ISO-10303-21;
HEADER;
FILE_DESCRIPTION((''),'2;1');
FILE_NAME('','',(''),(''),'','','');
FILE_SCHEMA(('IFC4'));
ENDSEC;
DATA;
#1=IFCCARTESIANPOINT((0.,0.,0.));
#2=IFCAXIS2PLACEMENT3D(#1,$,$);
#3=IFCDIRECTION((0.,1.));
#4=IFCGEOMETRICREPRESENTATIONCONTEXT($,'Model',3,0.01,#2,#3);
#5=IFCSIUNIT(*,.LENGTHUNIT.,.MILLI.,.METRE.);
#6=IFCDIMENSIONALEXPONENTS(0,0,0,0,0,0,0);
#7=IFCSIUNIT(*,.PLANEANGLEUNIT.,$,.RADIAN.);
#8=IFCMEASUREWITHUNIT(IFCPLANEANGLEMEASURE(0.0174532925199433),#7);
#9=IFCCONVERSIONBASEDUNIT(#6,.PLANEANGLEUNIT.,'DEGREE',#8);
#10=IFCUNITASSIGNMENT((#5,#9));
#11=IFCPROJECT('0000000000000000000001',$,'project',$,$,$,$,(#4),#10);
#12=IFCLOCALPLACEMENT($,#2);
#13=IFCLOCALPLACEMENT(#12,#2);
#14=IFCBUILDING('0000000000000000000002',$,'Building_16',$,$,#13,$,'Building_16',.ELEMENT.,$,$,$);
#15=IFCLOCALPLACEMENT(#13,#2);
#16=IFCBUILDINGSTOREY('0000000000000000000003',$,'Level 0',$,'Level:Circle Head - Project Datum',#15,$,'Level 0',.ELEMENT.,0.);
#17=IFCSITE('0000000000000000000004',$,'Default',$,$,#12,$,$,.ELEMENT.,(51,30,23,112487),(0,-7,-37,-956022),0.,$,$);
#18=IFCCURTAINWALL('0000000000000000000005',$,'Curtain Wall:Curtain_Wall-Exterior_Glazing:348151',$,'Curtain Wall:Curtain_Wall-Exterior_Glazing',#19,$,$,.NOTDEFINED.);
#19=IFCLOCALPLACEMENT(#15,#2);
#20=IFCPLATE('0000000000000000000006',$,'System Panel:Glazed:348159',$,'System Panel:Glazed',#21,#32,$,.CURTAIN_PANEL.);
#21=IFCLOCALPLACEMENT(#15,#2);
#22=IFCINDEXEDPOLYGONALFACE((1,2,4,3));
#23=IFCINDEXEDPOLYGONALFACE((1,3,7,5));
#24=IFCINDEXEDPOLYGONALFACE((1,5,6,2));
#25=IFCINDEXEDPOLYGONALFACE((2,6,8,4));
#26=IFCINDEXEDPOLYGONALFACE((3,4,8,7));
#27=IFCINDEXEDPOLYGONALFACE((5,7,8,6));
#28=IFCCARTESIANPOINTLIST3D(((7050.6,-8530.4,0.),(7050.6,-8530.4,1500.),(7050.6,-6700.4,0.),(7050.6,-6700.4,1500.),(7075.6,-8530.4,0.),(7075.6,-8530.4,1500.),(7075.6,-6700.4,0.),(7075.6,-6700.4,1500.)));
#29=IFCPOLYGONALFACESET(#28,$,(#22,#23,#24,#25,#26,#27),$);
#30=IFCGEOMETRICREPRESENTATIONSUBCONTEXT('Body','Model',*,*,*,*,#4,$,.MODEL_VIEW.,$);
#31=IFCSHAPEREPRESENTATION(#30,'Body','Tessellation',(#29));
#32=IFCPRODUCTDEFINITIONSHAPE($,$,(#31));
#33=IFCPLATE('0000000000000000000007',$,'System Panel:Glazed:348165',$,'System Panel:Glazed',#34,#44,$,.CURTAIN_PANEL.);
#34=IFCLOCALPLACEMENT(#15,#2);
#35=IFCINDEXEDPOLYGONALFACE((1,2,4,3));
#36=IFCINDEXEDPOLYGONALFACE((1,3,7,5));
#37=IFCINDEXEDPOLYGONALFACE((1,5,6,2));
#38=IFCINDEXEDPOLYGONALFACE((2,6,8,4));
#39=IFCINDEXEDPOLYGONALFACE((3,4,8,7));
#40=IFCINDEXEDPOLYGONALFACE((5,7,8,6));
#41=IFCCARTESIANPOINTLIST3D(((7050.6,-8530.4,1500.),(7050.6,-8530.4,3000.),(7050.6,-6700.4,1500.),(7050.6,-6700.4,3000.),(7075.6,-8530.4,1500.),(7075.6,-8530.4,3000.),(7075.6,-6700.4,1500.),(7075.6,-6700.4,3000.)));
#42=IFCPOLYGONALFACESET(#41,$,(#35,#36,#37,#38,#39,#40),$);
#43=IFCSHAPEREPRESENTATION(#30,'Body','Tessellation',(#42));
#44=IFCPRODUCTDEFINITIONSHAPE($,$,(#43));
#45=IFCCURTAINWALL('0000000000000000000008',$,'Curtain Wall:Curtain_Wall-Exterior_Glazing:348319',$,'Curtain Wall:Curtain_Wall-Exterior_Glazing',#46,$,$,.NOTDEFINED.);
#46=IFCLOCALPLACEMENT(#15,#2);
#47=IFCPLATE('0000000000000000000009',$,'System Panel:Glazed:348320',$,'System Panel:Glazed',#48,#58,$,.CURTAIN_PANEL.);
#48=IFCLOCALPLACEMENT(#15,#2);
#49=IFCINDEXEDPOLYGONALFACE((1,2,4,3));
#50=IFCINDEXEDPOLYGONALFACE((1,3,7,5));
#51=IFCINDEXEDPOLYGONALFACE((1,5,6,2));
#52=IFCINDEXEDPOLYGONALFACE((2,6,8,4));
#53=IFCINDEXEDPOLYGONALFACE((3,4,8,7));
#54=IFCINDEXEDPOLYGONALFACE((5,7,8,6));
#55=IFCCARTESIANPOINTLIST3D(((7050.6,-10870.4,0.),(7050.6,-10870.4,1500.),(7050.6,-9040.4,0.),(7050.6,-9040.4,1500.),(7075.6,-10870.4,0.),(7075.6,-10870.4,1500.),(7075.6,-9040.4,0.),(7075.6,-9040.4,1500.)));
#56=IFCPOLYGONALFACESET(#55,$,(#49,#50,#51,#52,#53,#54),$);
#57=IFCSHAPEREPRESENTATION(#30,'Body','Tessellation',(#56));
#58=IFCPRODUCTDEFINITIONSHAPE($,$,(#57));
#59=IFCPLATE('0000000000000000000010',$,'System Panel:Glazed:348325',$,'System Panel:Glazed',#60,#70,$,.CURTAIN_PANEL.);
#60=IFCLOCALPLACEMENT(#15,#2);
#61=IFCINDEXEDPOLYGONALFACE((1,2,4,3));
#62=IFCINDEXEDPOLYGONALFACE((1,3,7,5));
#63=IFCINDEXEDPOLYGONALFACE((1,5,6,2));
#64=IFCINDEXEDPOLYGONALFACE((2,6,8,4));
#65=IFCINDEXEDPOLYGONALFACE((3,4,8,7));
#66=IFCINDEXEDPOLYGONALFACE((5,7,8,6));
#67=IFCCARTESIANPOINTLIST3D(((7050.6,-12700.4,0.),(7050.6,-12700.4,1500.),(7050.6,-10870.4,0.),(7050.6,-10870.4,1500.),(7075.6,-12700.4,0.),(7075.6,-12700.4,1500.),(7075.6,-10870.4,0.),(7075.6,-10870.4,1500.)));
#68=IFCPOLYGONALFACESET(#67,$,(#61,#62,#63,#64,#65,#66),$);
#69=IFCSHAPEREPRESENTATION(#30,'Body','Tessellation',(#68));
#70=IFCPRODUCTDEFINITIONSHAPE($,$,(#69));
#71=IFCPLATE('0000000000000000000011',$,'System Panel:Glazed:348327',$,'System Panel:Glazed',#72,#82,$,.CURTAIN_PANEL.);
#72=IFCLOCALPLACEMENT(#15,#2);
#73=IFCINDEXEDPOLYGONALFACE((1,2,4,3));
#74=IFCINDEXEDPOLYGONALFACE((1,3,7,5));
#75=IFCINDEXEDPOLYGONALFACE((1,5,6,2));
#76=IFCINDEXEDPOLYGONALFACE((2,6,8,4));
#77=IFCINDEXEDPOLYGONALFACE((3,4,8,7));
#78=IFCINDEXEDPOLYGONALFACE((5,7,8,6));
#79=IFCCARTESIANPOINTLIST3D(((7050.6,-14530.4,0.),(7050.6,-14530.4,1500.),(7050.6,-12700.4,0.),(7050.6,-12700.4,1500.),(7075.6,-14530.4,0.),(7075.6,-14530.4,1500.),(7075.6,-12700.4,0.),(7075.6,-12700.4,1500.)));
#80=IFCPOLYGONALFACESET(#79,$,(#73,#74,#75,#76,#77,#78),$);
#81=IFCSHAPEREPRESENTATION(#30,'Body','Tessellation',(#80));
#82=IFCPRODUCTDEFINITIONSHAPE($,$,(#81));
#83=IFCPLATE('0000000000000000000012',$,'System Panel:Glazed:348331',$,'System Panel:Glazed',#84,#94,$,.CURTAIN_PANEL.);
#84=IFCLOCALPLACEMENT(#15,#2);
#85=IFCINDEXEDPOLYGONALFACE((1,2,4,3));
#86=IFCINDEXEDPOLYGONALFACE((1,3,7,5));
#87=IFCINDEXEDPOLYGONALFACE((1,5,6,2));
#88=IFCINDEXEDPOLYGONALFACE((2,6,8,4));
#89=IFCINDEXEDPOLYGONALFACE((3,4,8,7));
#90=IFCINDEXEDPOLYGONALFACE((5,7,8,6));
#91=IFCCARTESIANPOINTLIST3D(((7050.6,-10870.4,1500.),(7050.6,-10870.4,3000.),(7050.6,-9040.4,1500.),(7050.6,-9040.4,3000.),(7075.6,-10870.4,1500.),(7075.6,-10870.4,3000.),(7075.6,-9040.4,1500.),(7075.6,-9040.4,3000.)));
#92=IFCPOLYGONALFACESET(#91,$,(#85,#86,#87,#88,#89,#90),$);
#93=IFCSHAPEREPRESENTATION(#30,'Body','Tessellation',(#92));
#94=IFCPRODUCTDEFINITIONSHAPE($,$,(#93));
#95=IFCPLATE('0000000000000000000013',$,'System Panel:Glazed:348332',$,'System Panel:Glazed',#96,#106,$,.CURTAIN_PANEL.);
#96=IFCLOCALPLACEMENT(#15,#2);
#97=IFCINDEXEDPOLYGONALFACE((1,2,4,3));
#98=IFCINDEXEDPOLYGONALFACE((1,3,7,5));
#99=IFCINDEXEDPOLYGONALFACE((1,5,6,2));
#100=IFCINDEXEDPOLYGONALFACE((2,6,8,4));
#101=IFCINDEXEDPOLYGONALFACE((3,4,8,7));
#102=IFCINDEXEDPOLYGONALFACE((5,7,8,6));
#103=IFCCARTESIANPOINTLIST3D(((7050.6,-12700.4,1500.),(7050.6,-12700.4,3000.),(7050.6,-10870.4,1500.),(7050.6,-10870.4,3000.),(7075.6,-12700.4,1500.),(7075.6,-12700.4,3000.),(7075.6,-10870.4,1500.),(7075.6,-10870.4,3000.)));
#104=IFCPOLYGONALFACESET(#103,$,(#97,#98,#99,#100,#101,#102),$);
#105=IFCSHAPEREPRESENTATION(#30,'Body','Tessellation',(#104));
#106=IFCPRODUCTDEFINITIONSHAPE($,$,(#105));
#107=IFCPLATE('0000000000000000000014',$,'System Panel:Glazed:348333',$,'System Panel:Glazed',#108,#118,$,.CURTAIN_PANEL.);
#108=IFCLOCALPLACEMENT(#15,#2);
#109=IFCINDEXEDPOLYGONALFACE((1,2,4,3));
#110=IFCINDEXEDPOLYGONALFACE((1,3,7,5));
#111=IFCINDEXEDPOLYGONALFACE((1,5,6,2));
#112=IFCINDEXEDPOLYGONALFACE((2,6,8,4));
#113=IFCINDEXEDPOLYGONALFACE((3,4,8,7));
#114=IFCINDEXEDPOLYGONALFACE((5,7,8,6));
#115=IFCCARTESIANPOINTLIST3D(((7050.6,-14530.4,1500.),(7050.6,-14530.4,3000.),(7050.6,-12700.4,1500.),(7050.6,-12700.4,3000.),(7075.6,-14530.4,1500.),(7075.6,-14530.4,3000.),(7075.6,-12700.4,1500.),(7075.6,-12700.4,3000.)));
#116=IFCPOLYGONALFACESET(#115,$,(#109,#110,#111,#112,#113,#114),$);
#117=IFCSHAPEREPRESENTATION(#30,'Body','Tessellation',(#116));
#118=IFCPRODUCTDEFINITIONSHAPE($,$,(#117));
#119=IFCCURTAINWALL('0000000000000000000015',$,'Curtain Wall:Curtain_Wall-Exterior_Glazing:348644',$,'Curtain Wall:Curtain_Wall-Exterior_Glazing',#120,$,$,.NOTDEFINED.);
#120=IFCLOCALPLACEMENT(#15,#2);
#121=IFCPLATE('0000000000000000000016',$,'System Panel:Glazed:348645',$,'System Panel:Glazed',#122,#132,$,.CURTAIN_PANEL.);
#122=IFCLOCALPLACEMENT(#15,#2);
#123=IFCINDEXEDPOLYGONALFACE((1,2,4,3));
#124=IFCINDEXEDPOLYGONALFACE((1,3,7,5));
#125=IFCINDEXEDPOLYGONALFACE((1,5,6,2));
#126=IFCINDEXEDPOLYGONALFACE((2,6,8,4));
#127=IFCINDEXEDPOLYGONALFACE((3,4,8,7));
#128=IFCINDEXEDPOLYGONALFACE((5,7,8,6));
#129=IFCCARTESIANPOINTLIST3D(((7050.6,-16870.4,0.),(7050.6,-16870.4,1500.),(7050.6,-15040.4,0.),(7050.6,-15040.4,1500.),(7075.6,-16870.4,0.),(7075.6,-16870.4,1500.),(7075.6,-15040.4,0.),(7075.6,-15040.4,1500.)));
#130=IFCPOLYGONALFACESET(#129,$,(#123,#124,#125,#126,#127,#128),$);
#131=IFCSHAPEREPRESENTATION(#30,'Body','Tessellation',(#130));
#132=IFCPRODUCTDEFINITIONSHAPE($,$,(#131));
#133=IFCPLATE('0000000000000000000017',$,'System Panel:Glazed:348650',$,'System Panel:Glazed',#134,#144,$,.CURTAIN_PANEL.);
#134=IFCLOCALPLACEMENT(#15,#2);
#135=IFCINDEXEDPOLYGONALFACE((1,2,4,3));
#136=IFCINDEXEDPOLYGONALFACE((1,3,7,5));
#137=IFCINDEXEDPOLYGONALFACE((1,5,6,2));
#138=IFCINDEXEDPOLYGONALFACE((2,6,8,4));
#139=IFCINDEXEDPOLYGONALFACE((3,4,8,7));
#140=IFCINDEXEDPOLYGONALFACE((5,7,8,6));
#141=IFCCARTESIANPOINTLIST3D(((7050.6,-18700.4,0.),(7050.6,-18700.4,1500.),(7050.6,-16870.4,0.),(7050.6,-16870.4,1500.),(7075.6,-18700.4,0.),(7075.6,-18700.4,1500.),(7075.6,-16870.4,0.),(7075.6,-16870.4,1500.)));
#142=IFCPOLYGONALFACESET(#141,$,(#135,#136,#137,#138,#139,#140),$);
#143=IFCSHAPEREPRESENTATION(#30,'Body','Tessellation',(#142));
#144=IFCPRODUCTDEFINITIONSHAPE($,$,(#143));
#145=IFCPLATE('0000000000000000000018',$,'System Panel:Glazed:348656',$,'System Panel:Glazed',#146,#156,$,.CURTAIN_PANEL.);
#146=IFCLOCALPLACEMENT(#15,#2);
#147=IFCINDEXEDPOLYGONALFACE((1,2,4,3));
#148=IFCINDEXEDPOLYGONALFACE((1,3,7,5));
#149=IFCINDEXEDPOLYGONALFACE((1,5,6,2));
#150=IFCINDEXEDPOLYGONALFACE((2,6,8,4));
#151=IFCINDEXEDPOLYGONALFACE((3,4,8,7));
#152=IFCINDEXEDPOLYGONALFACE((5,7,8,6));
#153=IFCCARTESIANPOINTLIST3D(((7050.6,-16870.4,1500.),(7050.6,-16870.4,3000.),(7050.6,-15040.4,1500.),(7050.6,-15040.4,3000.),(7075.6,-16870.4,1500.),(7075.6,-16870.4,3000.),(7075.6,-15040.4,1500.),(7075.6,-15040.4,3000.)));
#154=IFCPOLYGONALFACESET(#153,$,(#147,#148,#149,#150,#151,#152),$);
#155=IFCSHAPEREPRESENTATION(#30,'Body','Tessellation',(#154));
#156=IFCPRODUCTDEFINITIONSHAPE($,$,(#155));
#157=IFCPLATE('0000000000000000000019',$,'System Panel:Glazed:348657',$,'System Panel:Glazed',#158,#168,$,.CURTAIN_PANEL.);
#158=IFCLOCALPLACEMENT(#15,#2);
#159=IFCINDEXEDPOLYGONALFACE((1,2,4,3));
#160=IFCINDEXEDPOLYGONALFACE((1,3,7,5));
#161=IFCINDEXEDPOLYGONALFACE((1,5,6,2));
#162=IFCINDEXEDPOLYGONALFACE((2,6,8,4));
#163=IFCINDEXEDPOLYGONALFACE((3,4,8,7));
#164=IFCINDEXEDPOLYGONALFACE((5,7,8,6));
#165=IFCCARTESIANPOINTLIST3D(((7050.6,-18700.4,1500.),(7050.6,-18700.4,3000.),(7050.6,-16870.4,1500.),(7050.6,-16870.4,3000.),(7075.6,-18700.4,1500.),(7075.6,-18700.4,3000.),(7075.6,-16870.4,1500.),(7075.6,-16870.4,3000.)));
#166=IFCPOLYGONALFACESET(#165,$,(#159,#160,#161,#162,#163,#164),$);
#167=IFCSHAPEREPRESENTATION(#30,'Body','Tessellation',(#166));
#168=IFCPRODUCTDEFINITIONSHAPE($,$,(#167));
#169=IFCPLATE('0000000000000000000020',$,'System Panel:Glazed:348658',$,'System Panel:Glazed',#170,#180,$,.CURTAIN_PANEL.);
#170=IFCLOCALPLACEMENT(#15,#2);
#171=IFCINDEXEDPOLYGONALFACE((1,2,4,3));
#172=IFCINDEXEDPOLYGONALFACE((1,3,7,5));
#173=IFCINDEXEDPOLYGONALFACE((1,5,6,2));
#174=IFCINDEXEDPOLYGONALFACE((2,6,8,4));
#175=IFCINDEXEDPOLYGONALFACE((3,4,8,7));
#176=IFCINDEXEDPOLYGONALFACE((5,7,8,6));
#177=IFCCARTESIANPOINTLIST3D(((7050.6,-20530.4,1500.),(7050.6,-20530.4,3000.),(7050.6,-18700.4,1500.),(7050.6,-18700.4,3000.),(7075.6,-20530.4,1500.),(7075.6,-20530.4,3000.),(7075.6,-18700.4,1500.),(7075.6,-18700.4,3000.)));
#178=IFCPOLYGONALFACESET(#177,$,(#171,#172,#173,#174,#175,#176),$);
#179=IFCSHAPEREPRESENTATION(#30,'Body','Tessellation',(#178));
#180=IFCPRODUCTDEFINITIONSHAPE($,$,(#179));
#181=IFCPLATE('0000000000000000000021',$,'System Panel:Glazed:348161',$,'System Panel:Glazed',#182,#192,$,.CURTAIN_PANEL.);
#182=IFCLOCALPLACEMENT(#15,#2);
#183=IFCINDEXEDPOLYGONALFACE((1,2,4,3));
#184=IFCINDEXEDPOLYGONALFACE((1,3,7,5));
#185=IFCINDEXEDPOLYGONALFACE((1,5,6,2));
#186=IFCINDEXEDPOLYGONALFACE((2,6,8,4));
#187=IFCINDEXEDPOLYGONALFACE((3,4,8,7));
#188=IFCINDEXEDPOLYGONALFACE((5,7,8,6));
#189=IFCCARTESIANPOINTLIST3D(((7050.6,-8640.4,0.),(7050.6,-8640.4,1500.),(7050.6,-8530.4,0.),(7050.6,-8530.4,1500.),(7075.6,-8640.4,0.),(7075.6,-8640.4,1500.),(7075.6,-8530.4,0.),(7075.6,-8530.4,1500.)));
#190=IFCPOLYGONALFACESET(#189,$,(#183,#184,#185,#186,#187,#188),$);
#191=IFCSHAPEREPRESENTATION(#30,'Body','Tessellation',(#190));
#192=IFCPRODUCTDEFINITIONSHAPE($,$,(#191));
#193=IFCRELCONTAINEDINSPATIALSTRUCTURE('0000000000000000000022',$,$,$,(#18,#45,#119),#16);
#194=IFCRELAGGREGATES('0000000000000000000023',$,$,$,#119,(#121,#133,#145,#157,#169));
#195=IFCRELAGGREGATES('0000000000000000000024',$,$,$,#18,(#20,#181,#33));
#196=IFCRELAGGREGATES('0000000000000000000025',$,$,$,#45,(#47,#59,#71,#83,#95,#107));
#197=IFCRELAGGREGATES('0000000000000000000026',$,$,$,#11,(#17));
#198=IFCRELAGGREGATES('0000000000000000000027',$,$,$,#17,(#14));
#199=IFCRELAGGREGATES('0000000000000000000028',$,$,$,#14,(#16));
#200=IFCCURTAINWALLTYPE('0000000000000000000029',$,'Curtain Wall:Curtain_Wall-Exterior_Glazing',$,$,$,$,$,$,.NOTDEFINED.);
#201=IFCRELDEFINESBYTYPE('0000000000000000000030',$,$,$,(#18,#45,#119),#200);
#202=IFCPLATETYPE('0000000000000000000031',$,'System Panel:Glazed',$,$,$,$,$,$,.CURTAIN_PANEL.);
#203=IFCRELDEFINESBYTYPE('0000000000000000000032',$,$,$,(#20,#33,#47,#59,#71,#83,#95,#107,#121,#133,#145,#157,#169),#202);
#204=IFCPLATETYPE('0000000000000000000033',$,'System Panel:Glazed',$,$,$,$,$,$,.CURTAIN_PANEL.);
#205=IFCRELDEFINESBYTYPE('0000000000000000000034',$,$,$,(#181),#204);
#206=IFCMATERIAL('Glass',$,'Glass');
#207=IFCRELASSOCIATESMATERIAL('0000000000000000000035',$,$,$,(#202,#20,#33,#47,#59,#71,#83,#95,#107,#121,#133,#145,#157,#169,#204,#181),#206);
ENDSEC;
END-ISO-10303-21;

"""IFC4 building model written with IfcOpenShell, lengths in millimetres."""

from ifc_helpers import new_model, entity, si_unit, converted_unit, direction, frame, origin, place, context, subcontext, project, spatial, indexed_curve, outline, extrude, source, transform, mapped, material, type_object, type_shapes, element, aggregate, save


model = new_model("IFC4")

# Units and contexts
model_context = context("Model", 3, precision=0.01, world=origin(), true_north=direction((0.0, 1.0)))
body_context = subcontext(model_context, "Body", "Model", "MODEL_VIEW")
ifc_project = project(units=[si_unit("LENGTHUNIT", "METRE", prefix="MILLI"), converted_unit("PLANEANGLEUNIT", "DEGREE", entity("IfcPlaneAngleMeasure", 0.0174532925199433), si_unit("PLANEANGLEUNIT", "RADIAN"), dimensions=[0, 0, 0, 0, 0, 0, 0])], contexts=[model_context])

# Site, building, storey
site_placement = place(None, origin())
site = spatial("IfcSite", under=ifc_project, at=site_placement, Name="Default", CompositionType="ELEMENT", RefLatitude=(51, 30, 23, 112487), RefLongitude=(0, -7, -37, -956022), RefElevation=0.0)
building_placement = place(site_placement, origin())
building = spatial("IfcBuilding", under=site, at=building_placement, Name="Building_16", LongName="Building_16", CompositionType="ELEMENT")
storey_placement = place(building_placement, origin())
storey = spatial("IfcBuildingStorey", under=building, at=storey_placement, Name="Level 0", ObjectType="Level:Circle Head - Project Datum", LongName="Level 0", CompositionType="ELEMENT", Elevation=0.0)

# Curtain walls, plates
curtain_wall_type = type_object("IfcCurtainWallType", Name="Curtain Wall:Curtain_Wall-Exterior_Glazing", PredefinedType="NOTDEFINED")
curtain_wall_1_placement = place(storey_placement, origin())
curtain_wall_1 = element("IfcCurtainWall", 1, at=curtain_wall_1_placement, inside=storey, type_object=curtain_wall_type, Name="Curtain Wall:Curtain_Wall-Exterior_Glazing:348151", ObjectType="Curtain Wall:Curtain_Wall-Exterior_Glazing", PredefinedType="NOTDEFINED")
ifc_material_1 = material(Name="Glass", Category="Glass")
plate_type_1 = type_object("IfcPlateType", Name="System Panel:Glazed", PredefinedType="CURTAIN_PANEL", material=ifc_material_1)
shared_shape_1 = source(origin(), body_context, "Body", "SweptSolid", [
    extrude(outline(indexed_curve([(-12.5, -915.0), (12.5, -915.0), (12.5, 915.0), (-12.5, 915.0), (-12.5, -915.0)], self_intersect=False)), frame((0.0, 37.0, 0.0), z_axis=(0.0, 0.0, 1.0), x_axis=(0.0, 1.0, 0.0)), (0.0, 0.0, 1.0), 1500.0),
])
type_shapes(plate_type_1, [shared_shape_1])
plate_1_placement = place(curtain_wall_1_placement, frame((7026.1, -7615.4, 0.0), z_axis=(0.0, 0.0, 1.0), x_axis=(0.0, -1.0, 0.0)))
plate_1 = element("IfcPlate", 2, at=plate_1_placement, type_object=plate_type_1, material=ifc_material_1, Name="System Panel:Glazed:348159", ObjectType="System Panel:Glazed", PredefinedType="CURTAIN_PANEL", context=body_context, shape_type="MappedRepresentation", body=[
    mapped(shared_shape_1, transform((0.0, 0.0, 0.0), scale=1.0)),
])
plate_2_placement = place(curtain_wall_1_placement, frame((7026.1, -7615.4, 1500.0), z_axis=(0.0, 0.0, 1.0), x_axis=(0.0, -1.0, 0.0)))
plate_2 = element("IfcPlate", 3, at=plate_2_placement, type_object=plate_type_1, material=ifc_material_1, Name="System Panel:Glazed:348165", ObjectType="System Panel:Glazed", PredefinedType="CURTAIN_PANEL", context=body_context, shape_type="MappedRepresentation", body=[
    mapped(shared_shape_1, transform((0.0, 0.0, 0.0), scale=1.0)),
])
curtain_wall_2_placement = place(storey_placement, origin())
curtain_wall_2 = element("IfcCurtainWall", 4, at=curtain_wall_2_placement, inside=storey, type_object=curtain_wall_type, Name="Curtain Wall:Curtain_Wall-Exterior_Glazing:348319", ObjectType="Curtain Wall:Curtain_Wall-Exterior_Glazing", PredefinedType="NOTDEFINED")
plate_3_placement = place(curtain_wall_2_placement, frame((7026.1, -9955.4, 0.0), z_axis=(0.0, 0.0, 1.0), x_axis=(0.0, -1.0, 0.0)))
plate_3 = element("IfcPlate", 5, at=plate_3_placement, type_object=plate_type_1, material=ifc_material_1, Name="System Panel:Glazed:348320", ObjectType="System Panel:Glazed", PredefinedType="CURTAIN_PANEL", context=body_context, shape_type="MappedRepresentation", body=[
    mapped(shared_shape_1, transform((0.0, 0.0, 0.0), scale=1.0)),
])
plate_4_placement = place(curtain_wall_2_placement, frame((7026.1, -11785.4, 0.0), z_axis=(0.0, 0.0, 1.0), x_axis=(0.0, -1.0, 0.0)))
plate_4 = element("IfcPlate", 6, at=plate_4_placement, type_object=plate_type_1, material=ifc_material_1, Name="System Panel:Glazed:348325", ObjectType="System Panel:Glazed", PredefinedType="CURTAIN_PANEL", context=body_context, shape_type="MappedRepresentation", body=[
    mapped(shared_shape_1, transform((0.0, 0.0, 0.0), scale=1.0)),
])
plate_5_placement = place(curtain_wall_2_placement, frame((7026.1, -13615.4, 0.0), z_axis=(0.0, 0.0, 1.0), x_axis=(0.0, -1.0, 0.0)))
plate_5 = element("IfcPlate", 7, at=plate_5_placement, type_object=plate_type_1, material=ifc_material_1, Name="System Panel:Glazed:348327", ObjectType="System Panel:Glazed", PredefinedType="CURTAIN_PANEL", context=body_context, shape_type="MappedRepresentation", body=[
    mapped(shared_shape_1, transform((0.0, 0.0, 0.0), scale=1.0)),
])
plate_6_placement = place(curtain_wall_2_placement, frame((7026.1, -9955.4, 1500.0), z_axis=(0.0, 0.0, 1.0), x_axis=(0.0, -1.0, 0.0)))
plate_6 = element("IfcPlate", 8, at=plate_6_placement, type_object=plate_type_1, material=ifc_material_1, Name="System Panel:Glazed:348331", ObjectType="System Panel:Glazed", PredefinedType="CURTAIN_PANEL", context=body_context, shape_type="MappedRepresentation", body=[
    mapped(shared_shape_1, transform((0.0, 0.0, 0.0), scale=1.0)),
])
plate_7_placement = place(curtain_wall_2_placement, frame((7026.1, -11785.4, 1500.0), z_axis=(0.0, 0.0, 1.0), x_axis=(0.0, -1.0, 0.0)))
plate_7 = element("IfcPlate", 9, at=plate_7_placement, type_object=plate_type_1, material=ifc_material_1, Name="System Panel:Glazed:348332", ObjectType="System Panel:Glazed", PredefinedType="CURTAIN_PANEL", context=body_context, shape_type="MappedRepresentation", body=[
    mapped(shared_shape_1, transform((0.0, 0.0, 0.0), scale=1.0)),
])
plate_8_placement = place(curtain_wall_2_placement, frame((7026.1, -13615.4, 1500.0), z_axis=(0.0, 0.0, 1.0), x_axis=(0.0, -1.0, 0.0)))
plate_8 = element("IfcPlate", 10, at=plate_8_placement, type_object=plate_type_1, material=ifc_material_1, Name="System Panel:Glazed:348333", ObjectType="System Panel:Glazed", PredefinedType="CURTAIN_PANEL", context=body_context, shape_type="MappedRepresentation", body=[
    mapped(shared_shape_1, transform((0.0, 0.0, 0.0), scale=1.0)),
])
curtain_wall_3_placement = place(storey_placement, origin())
curtain_wall_3 = element("IfcCurtainWall", 11, at=curtain_wall_3_placement, inside=storey, type_object=curtain_wall_type, Name="Curtain Wall:Curtain_Wall-Exterior_Glazing:348644", ObjectType="Curtain Wall:Curtain_Wall-Exterior_Glazing", PredefinedType="NOTDEFINED")
plate_9_placement = place(curtain_wall_3_placement, frame((7026.1, -15955.4, 0.0), z_axis=(0.0, 0.0, 1.0), x_axis=(0.0, -1.0, 0.0)))
plate_9 = element("IfcPlate", 12, at=plate_9_placement, type_object=plate_type_1, material=ifc_material_1, Name="System Panel:Glazed:348645", ObjectType="System Panel:Glazed", PredefinedType="CURTAIN_PANEL", context=body_context, shape_type="MappedRepresentation", body=[
    mapped(shared_shape_1, transform((0.0, 0.0, 0.0), scale=1.0)),
])
plate_10_placement = place(curtain_wall_3_placement, frame((7026.1, -17785.4, 0.0), z_axis=(0.0, 0.0, 1.0), x_axis=(0.0, -1.0, 0.0)))
plate_10 = element("IfcPlate", 13, at=plate_10_placement, type_object=plate_type_1, material=ifc_material_1, Name="System Panel:Glazed:348650", ObjectType="System Panel:Glazed", PredefinedType="CURTAIN_PANEL", context=body_context, shape_type="MappedRepresentation", body=[
    mapped(shared_shape_1, transform((0.0, 0.0, 0.0), scale=1.0)),
])
plate_11_placement = place(curtain_wall_3_placement, frame((7026.1, -15955.4, 1500.0), z_axis=(0.0, 0.0, 1.0), x_axis=(0.0, -1.0, 0.0)))
plate_11 = element("IfcPlate", 14, at=plate_11_placement, type_object=plate_type_1, material=ifc_material_1, Name="System Panel:Glazed:348656", ObjectType="System Panel:Glazed", PredefinedType="CURTAIN_PANEL", context=body_context, shape_type="MappedRepresentation", body=[
    mapped(shared_shape_1, transform((0.0, 0.0, 0.0), scale=1.0)),
])
plate_12_placement = place(curtain_wall_3_placement, frame((7026.1, -17785.4, 1500.0), z_axis=(0.0, 0.0, 1.0), x_axis=(0.0, -1.0, 0.0)))
plate_12 = element("IfcPlate", 15, at=plate_12_placement, type_object=plate_type_1, material=ifc_material_1, Name="System Panel:Glazed:348657", ObjectType="System Panel:Glazed", PredefinedType="CURTAIN_PANEL", context=body_context, shape_type="MappedRepresentation", body=[
    mapped(shared_shape_1, transform((0.0, 0.0, 0.0), scale=1.0)),
])
plate_13_placement = place(curtain_wall_3_placement, frame((7026.1, -19615.4, 1500.0), z_axis=(0.0, 0.0, 1.0), x_axis=(0.0, -1.0, 0.0)))
plate_13 = element("IfcPlate", 16, at=plate_13_placement, type_object=plate_type_1, material=ifc_material_1, Name="System Panel:Glazed:348658", ObjectType="System Panel:Glazed", PredefinedType="CURTAIN_PANEL", context=body_context, shape_type="MappedRepresentation", body=[
    mapped(shared_shape_1, transform((0.0, 0.0, 0.0), scale=1.0)),
])

# Plate
plate_type_2 = type_object("IfcPlateType", Name="System Panel:Glazed", PredefinedType="CURTAIN_PANEL", material=ifc_material_1)
shared_shape_2 = source(origin(), body_context, "Body", "SweptSolid", [
    extrude(outline(indexed_curve([(-12.5, -55.0), (12.5, -55.0), (12.5, 55.0), (-12.5, 55.0), (-12.5, -55.0)], self_intersect=False)), frame((0.0, 37.0, 0.0), z_axis=(0.0, 0.0, 1.0), x_axis=(0.0, 1.0, 0.0)), (0.0, 0.0, 1.0), 1500.0),
])
type_shapes(plate_type_2, [shared_shape_2])
plate_14_placement = place(curtain_wall_1_placement, frame((7026.1, -8585.4, 0.0), z_axis=(0.0, 0.0, 1.0), x_axis=(0.0, -1.0, 0.0)))
plate_14 = element("IfcPlate", 17, at=plate_14_placement, type_object=plate_type_2, material=ifc_material_1, Name="System Panel:Glazed:348161", ObjectType="System Panel:Glazed", PredefinedType="CURTAIN_PANEL", context=body_context, shape_type="MappedRepresentation", body=[
    mapped(shared_shape_2, transform((0.0, 0.0, 0.0), scale=1.0)),
])
aggregate(curtain_wall_3, [plate_9, plate_10, plate_11, plate_12, plate_13])

aggregate(curtain_wall_1, [plate_1, plate_14, plate_2])
aggregate(curtain_wall_2, [plate_3, plate_4, plate_5, plate_6, plate_7, plate_8])

save(model, "model.ifc")
